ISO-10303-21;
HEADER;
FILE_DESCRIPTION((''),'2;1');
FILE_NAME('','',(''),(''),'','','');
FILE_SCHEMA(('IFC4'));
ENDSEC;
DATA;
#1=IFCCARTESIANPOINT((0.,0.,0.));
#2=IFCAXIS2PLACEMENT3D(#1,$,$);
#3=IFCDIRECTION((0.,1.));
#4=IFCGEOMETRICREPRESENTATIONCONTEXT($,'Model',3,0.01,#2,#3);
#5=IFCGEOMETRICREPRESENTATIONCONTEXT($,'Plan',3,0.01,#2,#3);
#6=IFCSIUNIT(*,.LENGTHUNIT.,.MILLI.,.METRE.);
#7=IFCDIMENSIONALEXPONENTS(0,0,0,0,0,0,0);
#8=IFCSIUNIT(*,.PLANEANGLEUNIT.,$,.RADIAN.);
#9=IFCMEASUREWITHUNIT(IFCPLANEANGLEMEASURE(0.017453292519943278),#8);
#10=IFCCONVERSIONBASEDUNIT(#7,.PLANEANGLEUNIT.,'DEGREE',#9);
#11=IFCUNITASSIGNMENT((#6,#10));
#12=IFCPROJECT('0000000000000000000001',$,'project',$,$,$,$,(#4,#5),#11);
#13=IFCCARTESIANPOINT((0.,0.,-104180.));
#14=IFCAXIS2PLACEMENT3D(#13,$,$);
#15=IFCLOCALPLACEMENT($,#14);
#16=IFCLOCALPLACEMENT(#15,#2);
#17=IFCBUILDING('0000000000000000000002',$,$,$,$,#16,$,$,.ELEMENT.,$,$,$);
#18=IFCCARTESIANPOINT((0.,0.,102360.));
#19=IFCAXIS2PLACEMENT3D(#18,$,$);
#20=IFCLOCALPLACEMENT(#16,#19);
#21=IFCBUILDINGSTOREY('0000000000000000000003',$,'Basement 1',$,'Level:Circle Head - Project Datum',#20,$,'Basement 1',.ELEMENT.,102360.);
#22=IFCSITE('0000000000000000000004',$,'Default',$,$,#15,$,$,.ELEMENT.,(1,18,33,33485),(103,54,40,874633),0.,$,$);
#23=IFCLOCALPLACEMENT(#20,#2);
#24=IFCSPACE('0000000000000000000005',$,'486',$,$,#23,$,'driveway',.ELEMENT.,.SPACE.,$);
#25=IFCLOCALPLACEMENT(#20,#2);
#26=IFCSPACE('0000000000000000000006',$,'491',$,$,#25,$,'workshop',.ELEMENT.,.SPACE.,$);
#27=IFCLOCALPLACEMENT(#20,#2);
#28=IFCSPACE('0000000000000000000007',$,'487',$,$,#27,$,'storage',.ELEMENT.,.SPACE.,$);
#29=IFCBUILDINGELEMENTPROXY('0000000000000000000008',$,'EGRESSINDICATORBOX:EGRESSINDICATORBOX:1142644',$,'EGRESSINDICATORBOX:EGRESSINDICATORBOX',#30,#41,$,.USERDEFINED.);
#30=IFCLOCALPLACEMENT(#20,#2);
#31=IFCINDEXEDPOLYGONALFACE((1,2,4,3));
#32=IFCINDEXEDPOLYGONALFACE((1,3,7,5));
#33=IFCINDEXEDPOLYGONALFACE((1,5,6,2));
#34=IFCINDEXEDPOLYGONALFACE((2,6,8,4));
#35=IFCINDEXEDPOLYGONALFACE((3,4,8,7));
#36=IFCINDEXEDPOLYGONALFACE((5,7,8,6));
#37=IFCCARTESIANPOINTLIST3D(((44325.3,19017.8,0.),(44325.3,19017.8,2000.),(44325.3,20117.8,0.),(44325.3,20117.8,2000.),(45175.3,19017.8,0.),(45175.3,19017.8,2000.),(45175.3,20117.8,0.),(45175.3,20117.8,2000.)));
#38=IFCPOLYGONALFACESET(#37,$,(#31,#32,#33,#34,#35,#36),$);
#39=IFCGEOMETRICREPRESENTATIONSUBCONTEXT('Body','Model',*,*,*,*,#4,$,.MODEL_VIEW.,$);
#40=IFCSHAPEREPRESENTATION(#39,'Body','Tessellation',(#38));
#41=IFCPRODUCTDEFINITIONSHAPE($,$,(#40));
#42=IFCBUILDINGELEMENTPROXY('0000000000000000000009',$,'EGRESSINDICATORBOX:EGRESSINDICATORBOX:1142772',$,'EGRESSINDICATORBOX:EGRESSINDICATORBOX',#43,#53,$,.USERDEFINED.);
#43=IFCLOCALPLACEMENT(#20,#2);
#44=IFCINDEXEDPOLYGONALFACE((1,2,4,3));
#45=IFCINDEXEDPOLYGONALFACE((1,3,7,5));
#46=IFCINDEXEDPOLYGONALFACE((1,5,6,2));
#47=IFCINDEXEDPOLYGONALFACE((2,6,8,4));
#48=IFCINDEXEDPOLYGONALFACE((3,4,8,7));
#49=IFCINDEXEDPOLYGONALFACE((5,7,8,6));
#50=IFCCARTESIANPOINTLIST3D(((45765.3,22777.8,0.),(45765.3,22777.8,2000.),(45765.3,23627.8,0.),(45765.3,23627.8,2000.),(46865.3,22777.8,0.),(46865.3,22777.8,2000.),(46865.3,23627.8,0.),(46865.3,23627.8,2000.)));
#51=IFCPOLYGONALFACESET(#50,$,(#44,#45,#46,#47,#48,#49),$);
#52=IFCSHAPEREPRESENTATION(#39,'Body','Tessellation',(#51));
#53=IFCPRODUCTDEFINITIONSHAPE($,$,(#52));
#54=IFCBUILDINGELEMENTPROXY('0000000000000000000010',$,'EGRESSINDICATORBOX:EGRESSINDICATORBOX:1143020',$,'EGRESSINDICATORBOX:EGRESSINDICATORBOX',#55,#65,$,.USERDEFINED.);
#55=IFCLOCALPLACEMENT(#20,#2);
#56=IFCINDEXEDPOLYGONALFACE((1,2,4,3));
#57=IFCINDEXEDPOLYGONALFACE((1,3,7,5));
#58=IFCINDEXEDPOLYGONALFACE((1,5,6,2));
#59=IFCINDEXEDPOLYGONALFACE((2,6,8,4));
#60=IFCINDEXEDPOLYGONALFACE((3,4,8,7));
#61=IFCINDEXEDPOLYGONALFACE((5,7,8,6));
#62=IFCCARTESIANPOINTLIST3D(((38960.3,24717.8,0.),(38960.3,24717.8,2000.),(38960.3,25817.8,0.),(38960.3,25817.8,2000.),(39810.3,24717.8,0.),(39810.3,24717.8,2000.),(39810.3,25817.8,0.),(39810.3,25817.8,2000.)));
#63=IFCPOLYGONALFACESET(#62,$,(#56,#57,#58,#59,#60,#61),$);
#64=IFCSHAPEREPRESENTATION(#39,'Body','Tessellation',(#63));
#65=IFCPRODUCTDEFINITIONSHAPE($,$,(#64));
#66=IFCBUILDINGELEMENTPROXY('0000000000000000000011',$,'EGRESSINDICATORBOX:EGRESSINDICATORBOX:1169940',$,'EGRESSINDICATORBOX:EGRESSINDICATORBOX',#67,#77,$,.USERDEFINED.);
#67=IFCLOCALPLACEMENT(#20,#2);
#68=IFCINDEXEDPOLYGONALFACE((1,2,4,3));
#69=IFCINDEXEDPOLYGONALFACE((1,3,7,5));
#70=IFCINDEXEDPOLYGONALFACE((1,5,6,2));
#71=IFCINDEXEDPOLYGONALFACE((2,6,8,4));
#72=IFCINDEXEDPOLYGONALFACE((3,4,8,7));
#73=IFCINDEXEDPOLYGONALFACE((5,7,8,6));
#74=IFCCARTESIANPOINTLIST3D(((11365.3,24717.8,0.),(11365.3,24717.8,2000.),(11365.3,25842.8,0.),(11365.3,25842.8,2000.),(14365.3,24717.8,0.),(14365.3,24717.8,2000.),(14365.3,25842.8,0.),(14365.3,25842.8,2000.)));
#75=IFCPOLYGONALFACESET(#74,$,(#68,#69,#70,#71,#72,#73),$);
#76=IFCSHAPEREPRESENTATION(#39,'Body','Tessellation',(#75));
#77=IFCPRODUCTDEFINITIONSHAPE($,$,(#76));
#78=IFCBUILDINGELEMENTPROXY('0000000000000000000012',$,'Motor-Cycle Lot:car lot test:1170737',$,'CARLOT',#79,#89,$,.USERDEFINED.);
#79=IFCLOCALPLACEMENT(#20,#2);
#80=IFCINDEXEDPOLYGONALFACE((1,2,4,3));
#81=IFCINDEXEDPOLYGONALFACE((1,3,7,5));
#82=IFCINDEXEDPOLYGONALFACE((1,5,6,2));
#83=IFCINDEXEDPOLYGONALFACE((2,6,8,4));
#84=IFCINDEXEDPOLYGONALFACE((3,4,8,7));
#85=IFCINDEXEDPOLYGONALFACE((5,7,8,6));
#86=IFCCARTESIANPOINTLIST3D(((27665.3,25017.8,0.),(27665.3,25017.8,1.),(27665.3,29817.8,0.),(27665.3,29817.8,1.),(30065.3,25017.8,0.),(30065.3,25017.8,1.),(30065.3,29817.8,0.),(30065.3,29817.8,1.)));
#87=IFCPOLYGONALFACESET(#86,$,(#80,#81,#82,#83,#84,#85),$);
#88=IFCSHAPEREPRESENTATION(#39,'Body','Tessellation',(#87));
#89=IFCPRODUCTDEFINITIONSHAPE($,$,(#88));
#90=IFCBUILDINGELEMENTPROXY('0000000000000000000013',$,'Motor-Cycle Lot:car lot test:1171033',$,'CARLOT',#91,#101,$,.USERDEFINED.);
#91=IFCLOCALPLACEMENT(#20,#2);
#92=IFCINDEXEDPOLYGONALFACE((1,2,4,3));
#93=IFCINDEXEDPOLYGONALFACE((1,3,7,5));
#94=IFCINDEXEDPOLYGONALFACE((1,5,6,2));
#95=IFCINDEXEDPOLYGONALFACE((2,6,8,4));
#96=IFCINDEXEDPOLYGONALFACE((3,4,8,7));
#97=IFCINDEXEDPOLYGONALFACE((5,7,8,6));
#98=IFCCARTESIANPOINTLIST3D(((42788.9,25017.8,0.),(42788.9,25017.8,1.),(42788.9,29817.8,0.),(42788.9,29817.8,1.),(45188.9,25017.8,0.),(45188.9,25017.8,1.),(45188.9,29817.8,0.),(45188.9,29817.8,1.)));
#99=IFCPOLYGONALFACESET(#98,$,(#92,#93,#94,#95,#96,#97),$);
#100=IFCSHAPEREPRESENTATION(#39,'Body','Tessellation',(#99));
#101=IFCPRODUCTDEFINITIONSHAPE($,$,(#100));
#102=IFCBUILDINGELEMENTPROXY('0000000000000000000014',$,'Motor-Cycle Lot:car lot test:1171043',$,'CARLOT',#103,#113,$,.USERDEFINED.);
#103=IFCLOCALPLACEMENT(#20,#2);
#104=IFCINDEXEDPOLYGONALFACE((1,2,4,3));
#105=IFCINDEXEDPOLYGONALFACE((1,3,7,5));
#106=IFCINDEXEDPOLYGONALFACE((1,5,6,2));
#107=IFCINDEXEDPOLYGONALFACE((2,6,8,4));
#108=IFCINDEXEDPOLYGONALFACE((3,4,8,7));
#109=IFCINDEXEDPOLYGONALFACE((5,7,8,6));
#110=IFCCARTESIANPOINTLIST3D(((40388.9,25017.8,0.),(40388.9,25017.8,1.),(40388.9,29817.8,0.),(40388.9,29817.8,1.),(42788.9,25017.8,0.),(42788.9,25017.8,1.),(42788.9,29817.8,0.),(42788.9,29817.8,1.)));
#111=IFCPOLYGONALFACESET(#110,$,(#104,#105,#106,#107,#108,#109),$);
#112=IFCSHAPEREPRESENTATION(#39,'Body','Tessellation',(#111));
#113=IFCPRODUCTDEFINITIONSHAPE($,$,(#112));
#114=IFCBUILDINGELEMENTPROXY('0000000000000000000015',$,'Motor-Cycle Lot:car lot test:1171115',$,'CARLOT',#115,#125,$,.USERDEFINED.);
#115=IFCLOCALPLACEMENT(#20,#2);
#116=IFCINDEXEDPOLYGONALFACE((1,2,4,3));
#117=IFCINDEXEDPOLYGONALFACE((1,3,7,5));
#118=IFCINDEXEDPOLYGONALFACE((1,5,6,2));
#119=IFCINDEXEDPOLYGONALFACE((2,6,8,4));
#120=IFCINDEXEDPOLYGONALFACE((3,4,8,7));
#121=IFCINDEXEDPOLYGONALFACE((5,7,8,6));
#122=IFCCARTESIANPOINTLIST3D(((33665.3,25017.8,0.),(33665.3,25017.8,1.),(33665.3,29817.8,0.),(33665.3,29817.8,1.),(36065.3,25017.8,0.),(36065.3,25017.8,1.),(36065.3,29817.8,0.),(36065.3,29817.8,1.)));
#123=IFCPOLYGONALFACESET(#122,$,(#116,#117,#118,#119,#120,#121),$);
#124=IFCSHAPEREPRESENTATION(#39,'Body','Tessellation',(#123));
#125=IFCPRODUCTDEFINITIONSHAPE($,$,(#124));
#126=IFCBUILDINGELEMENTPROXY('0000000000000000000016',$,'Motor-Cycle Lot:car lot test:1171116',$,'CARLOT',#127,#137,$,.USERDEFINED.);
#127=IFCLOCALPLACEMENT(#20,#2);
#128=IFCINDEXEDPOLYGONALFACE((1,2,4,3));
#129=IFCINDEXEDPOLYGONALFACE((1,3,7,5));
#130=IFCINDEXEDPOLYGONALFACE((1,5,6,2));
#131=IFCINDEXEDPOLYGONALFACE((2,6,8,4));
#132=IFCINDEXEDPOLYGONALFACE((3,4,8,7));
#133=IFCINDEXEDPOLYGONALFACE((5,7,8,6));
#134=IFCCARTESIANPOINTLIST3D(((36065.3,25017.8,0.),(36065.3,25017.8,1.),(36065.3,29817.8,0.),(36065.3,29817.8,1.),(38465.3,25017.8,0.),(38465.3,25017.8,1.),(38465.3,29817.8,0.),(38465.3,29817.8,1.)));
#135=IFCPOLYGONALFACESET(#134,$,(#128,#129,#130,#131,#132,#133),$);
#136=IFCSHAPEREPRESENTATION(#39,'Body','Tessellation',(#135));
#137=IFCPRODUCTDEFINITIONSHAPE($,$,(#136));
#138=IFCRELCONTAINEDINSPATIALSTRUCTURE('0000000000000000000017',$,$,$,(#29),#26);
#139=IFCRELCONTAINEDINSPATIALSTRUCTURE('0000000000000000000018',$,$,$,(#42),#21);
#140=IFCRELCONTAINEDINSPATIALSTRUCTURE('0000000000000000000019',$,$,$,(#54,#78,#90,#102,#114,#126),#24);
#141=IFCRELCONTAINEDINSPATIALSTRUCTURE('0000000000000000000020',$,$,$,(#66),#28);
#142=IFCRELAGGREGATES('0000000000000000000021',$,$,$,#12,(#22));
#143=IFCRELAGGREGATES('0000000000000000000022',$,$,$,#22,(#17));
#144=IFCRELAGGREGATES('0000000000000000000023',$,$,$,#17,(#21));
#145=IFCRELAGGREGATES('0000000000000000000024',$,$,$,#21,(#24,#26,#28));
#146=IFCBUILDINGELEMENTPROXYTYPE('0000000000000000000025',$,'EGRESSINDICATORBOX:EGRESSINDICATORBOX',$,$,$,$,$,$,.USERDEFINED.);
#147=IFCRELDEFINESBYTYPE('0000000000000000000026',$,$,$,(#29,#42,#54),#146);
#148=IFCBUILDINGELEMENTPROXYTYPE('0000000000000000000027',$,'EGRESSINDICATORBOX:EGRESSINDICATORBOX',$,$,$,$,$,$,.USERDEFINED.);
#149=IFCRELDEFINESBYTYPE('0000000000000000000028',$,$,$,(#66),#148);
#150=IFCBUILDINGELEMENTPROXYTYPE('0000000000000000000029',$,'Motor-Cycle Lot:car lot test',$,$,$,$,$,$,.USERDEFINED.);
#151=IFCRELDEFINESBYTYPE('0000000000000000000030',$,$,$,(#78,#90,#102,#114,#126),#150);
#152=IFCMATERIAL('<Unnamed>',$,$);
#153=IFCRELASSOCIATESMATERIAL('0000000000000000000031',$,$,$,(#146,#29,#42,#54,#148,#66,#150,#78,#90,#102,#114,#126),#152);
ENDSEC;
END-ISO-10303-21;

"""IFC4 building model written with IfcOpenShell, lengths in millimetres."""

from ifc_helpers import new_model, entity, si_unit, converted_unit, direction, frame, origin, place, context, subcontext, project, spatial, indexed_curve, outline, extrude, source, transform, mapped, material, type_object, type_shapes, element, save


model = new_model("IFC4")

# Units and contexts
model_context = context("Model", 3, precision=0.01, world=origin(), true_north=direction((0.0, 1.0)))
plan_context = context("Plan", 3, precision=0.01, world=origin(), true_north=direction((0.0, 1.0)))
body_context = subcontext(model_context, "Body", "Model", "MODEL_VIEW")
ifc_project = project(units=[si_unit("LENGTHUNIT", "METRE", prefix="MILLI"), converted_unit("PLANEANGLEUNIT", "DEGREE", entity("IfcPlaneAngleMeasure", 0.017453292519943278), si_unit("PLANEANGLEUNIT", "RADIAN"), dimensions=[0, 0, 0, 0, 0, 0, 0])], contexts=[model_context, plan_context])

# Site, building, storey
site_placement = place(None, frame((0.0, 0.0, -104180.0)))
site = spatial("IfcSite", under=ifc_project, at=site_placement, Name="Default", CompositionType="ELEMENT", RefLatitude=(1, 18, 33, 33485), RefLongitude=(103, 54, 40, 874633), RefElevation=0.0)
building_placement = place(site_placement, origin())
building = spatial("IfcBuilding", under=site, at=building_placement, CompositionType="ELEMENT")
storey_placement = place(building_placement, frame((0.0, 0.0, 102360.0)))
storey = spatial("IfcBuildingStorey", under=building, at=storey_placement, Name="Basement 1", ObjectType="Level:Circle Head - Project Datum", LongName="Basement 1", CompositionType="ELEMENT", Elevation=102360.0)

# Shared definitions
space_1_placement = place(storey_placement, origin())
space_1 = spatial("IfcSpace", under=storey, at=space_1_placement, Name="486", LongName="driveway", CompositionType="ELEMENT", PredefinedType="SPACE")

# Shared definitions
ifc_material_1 = material(Name="<Unnamed>")

# Shared definitions
space_2_placement = place(storey_placement, origin())
space_2 = spatial("IfcSpace", under=storey, at=space_2_placement, Name="491", LongName="workshop", CompositionType="ELEMENT", PredefinedType="SPACE")

# Shared definitions
space_3_placement = place(storey_placement, origin())
space_3 = spatial("IfcSpace", under=storey, at=space_3_placement, Name="487", LongName="storage", CompositionType="ELEMENT", PredefinedType="SPACE")

# Shared definitions
building_element_proxy_type_1 = type_object("IfcBuildingElementProxyType", Name="EGRESSINDICATORBOX:EGRESSINDICATORBOX", PredefinedType="USERDEFINED", material=ifc_material_1)
shared_shape_1 = source(origin(), body_context, "Body", "SweptSolid", [
    extrude(outline(indexed_curve([(-425.0, -550.0), (425.0, -550.0), (425.0, 550.0), (-425.0, 550.0), (-425.0, -550.0)], self_intersect=False)), frame((0.0, 0.0, 0.0), z_axis=(0.0, 0.0, 1.0), x_axis=(-1.0, 0.0, 0.0)), (0.0, 0.0, 1.0), 2000.0),
])
type_shapes(building_element_proxy_type_1, [shared_shape_1])

# Building element proxies
proxy_1_placement = place(space_2_placement, frame((44750.3, 19567.8, 0.0)))
element("IfcBuildingElementProxy", 1, at=proxy_1_placement, inside=space_2, type_object=building_element_proxy_type_1, material=ifc_material_1, Name="EGRESSINDICATORBOX:EGRESSINDICATORBOX:1142644", ObjectType="EGRESSINDICATORBOX:EGRESSINDICATORBOX", PredefinedType="USERDEFINED", context=body_context, shape_type="MappedRepresentation", body=[
    mapped(shared_shape_1, transform((0.0, 0.0, 0.0), scale=1.0)),
])
proxy_2_placement = place(storey_placement, frame((46315.3, 23202.8, 0.0), z_axis=(0.0, 0.0, 1.0), x_axis=(0.0, -1.0, 0.0)))
element("IfcBuildingElementProxy", 2, at=proxy_2_placement, inside=storey, type_object=building_element_proxy_type_1, material=ifc_material_1, Name="EGRESSINDICATORBOX:EGRESSINDICATORBOX:1142772", ObjectType="EGRESSINDICATORBOX:EGRESSINDICATORBOX", PredefinedType="USERDEFINED", context=body_context, shape_type="MappedRepresentation", body=[
    mapped(shared_shape_1, transform((0.0, 0.0, 0.0), scale=1.0)),
])
proxy_3_placement = place(space_1_placement, frame((39385.3, 25267.8, 0.0)))
element("IfcBuildingElementProxy", 3, at=proxy_3_placement, inside=space_1, type_object=building_element_proxy_type_1, material=ifc_material_1, Name="EGRESSINDICATORBOX:EGRESSINDICATORBOX:1143020", ObjectType="EGRESSINDICATORBOX:EGRESSINDICATORBOX", PredefinedType="USERDEFINED", context=body_context, shape_type="MappedRepresentation", body=[
    mapped(shared_shape_1, transform((0.0, 0.0, 0.0), scale=1.0)),
])
building_element_proxy_type_2 = type_object("IfcBuildingElementProxyType", Name="EGRESSINDICATORBOX:EGRESSINDICATORBOX", PredefinedType="USERDEFINED", material=ifc_material_1)
shared_shape_2 = source(origin(), body_context, "Body", "SweptSolid", [
    extrude(outline(indexed_curve([(-1500.0, -562.5), (1500.0, -562.5), (1500.0, 562.5), (-1500.0, 562.5), (-1500.0, -562.5)], self_intersect=False)), frame((0.0, 0.0, 0.0), z_axis=(0.0, 0.0, 1.0), x_axis=(-1.0, 0.0, 0.0)), (0.0, 0.0, 1.0), 2000.0),
])
type_shapes(building_element_proxy_type_2, [shared_shape_2])
proxy_4_placement = place(space_3_placement, frame((12865.3, 25280.3, 0.0)))
element("IfcBuildingElementProxy", 4, at=proxy_4_placement, inside=space_3, type_object=building_element_proxy_type_2, material=ifc_material_1, Name="EGRESSINDICATORBOX:EGRESSINDICATORBOX:1169940", ObjectType="EGRESSINDICATORBOX:EGRESSINDICATORBOX", PredefinedType="USERDEFINED", context=body_context, shape_type="MappedRepresentation", body=[
    mapped(shared_shape_2, transform((0.0, 0.0, 0.0), scale=1.0)),
])
building_element_proxy_type_3 = type_object("IfcBuildingElementProxyType", Name="Motor-Cycle Lot:car lot test", PredefinedType="USERDEFINED", material=ifc_material_1)
shared_shape_3 = source(origin(), body_context, "Body", "SweptSolid", [
    extrude(outline(indexed_curve([(-1200.0, -2400.0), (1200.0, -2400.0), (1200.0, 2400.0), (-1200.0, 2400.0), (-1200.0, -2400.0)], self_intersect=False)), frame((0.0, 0.0, 0.0), z_axis=(0.0, 0.0, 1.0), x_axis=(-1.0, 0.0, 0.0)), (0.0, 0.0, 1.0), 1.0),
])
type_shapes(building_element_proxy_type_3, [shared_shape_3])
for number, where, name in (
    (5, (28865.3, 27417.8, 0.0), "Motor-Cycle Lot:car lot test:1170737"),
    (6, (43988.9, 27417.8, 0.0), "Motor-Cycle Lot:car lot test:1171033"),
    (7, (41588.9, 27417.8, 0.0), "Motor-Cycle Lot:car lot test:1171043"),
    (8, (34865.3, 27417.8, 0.0), "Motor-Cycle Lot:car lot test:1171115"),
    (9, (37265.3, 27417.8, 0.0), "Motor-Cycle Lot:car lot test:1171116"),
):
    element("IfcBuildingElementProxy", number, at=place(space_1_placement, frame(where)), inside=space_1, type_object=building_element_proxy_type_3, material=ifc_material_1, Name=name, ObjectType="CARLOT", PredefinedType="USERDEFINED", context=body_context, shape_type="MappedRepresentation", body=[
        mapped(shared_shape_3, transform((0.0, 0.0, 0.0), scale=1.0)),
    ])

save(model, "model.ifc")
